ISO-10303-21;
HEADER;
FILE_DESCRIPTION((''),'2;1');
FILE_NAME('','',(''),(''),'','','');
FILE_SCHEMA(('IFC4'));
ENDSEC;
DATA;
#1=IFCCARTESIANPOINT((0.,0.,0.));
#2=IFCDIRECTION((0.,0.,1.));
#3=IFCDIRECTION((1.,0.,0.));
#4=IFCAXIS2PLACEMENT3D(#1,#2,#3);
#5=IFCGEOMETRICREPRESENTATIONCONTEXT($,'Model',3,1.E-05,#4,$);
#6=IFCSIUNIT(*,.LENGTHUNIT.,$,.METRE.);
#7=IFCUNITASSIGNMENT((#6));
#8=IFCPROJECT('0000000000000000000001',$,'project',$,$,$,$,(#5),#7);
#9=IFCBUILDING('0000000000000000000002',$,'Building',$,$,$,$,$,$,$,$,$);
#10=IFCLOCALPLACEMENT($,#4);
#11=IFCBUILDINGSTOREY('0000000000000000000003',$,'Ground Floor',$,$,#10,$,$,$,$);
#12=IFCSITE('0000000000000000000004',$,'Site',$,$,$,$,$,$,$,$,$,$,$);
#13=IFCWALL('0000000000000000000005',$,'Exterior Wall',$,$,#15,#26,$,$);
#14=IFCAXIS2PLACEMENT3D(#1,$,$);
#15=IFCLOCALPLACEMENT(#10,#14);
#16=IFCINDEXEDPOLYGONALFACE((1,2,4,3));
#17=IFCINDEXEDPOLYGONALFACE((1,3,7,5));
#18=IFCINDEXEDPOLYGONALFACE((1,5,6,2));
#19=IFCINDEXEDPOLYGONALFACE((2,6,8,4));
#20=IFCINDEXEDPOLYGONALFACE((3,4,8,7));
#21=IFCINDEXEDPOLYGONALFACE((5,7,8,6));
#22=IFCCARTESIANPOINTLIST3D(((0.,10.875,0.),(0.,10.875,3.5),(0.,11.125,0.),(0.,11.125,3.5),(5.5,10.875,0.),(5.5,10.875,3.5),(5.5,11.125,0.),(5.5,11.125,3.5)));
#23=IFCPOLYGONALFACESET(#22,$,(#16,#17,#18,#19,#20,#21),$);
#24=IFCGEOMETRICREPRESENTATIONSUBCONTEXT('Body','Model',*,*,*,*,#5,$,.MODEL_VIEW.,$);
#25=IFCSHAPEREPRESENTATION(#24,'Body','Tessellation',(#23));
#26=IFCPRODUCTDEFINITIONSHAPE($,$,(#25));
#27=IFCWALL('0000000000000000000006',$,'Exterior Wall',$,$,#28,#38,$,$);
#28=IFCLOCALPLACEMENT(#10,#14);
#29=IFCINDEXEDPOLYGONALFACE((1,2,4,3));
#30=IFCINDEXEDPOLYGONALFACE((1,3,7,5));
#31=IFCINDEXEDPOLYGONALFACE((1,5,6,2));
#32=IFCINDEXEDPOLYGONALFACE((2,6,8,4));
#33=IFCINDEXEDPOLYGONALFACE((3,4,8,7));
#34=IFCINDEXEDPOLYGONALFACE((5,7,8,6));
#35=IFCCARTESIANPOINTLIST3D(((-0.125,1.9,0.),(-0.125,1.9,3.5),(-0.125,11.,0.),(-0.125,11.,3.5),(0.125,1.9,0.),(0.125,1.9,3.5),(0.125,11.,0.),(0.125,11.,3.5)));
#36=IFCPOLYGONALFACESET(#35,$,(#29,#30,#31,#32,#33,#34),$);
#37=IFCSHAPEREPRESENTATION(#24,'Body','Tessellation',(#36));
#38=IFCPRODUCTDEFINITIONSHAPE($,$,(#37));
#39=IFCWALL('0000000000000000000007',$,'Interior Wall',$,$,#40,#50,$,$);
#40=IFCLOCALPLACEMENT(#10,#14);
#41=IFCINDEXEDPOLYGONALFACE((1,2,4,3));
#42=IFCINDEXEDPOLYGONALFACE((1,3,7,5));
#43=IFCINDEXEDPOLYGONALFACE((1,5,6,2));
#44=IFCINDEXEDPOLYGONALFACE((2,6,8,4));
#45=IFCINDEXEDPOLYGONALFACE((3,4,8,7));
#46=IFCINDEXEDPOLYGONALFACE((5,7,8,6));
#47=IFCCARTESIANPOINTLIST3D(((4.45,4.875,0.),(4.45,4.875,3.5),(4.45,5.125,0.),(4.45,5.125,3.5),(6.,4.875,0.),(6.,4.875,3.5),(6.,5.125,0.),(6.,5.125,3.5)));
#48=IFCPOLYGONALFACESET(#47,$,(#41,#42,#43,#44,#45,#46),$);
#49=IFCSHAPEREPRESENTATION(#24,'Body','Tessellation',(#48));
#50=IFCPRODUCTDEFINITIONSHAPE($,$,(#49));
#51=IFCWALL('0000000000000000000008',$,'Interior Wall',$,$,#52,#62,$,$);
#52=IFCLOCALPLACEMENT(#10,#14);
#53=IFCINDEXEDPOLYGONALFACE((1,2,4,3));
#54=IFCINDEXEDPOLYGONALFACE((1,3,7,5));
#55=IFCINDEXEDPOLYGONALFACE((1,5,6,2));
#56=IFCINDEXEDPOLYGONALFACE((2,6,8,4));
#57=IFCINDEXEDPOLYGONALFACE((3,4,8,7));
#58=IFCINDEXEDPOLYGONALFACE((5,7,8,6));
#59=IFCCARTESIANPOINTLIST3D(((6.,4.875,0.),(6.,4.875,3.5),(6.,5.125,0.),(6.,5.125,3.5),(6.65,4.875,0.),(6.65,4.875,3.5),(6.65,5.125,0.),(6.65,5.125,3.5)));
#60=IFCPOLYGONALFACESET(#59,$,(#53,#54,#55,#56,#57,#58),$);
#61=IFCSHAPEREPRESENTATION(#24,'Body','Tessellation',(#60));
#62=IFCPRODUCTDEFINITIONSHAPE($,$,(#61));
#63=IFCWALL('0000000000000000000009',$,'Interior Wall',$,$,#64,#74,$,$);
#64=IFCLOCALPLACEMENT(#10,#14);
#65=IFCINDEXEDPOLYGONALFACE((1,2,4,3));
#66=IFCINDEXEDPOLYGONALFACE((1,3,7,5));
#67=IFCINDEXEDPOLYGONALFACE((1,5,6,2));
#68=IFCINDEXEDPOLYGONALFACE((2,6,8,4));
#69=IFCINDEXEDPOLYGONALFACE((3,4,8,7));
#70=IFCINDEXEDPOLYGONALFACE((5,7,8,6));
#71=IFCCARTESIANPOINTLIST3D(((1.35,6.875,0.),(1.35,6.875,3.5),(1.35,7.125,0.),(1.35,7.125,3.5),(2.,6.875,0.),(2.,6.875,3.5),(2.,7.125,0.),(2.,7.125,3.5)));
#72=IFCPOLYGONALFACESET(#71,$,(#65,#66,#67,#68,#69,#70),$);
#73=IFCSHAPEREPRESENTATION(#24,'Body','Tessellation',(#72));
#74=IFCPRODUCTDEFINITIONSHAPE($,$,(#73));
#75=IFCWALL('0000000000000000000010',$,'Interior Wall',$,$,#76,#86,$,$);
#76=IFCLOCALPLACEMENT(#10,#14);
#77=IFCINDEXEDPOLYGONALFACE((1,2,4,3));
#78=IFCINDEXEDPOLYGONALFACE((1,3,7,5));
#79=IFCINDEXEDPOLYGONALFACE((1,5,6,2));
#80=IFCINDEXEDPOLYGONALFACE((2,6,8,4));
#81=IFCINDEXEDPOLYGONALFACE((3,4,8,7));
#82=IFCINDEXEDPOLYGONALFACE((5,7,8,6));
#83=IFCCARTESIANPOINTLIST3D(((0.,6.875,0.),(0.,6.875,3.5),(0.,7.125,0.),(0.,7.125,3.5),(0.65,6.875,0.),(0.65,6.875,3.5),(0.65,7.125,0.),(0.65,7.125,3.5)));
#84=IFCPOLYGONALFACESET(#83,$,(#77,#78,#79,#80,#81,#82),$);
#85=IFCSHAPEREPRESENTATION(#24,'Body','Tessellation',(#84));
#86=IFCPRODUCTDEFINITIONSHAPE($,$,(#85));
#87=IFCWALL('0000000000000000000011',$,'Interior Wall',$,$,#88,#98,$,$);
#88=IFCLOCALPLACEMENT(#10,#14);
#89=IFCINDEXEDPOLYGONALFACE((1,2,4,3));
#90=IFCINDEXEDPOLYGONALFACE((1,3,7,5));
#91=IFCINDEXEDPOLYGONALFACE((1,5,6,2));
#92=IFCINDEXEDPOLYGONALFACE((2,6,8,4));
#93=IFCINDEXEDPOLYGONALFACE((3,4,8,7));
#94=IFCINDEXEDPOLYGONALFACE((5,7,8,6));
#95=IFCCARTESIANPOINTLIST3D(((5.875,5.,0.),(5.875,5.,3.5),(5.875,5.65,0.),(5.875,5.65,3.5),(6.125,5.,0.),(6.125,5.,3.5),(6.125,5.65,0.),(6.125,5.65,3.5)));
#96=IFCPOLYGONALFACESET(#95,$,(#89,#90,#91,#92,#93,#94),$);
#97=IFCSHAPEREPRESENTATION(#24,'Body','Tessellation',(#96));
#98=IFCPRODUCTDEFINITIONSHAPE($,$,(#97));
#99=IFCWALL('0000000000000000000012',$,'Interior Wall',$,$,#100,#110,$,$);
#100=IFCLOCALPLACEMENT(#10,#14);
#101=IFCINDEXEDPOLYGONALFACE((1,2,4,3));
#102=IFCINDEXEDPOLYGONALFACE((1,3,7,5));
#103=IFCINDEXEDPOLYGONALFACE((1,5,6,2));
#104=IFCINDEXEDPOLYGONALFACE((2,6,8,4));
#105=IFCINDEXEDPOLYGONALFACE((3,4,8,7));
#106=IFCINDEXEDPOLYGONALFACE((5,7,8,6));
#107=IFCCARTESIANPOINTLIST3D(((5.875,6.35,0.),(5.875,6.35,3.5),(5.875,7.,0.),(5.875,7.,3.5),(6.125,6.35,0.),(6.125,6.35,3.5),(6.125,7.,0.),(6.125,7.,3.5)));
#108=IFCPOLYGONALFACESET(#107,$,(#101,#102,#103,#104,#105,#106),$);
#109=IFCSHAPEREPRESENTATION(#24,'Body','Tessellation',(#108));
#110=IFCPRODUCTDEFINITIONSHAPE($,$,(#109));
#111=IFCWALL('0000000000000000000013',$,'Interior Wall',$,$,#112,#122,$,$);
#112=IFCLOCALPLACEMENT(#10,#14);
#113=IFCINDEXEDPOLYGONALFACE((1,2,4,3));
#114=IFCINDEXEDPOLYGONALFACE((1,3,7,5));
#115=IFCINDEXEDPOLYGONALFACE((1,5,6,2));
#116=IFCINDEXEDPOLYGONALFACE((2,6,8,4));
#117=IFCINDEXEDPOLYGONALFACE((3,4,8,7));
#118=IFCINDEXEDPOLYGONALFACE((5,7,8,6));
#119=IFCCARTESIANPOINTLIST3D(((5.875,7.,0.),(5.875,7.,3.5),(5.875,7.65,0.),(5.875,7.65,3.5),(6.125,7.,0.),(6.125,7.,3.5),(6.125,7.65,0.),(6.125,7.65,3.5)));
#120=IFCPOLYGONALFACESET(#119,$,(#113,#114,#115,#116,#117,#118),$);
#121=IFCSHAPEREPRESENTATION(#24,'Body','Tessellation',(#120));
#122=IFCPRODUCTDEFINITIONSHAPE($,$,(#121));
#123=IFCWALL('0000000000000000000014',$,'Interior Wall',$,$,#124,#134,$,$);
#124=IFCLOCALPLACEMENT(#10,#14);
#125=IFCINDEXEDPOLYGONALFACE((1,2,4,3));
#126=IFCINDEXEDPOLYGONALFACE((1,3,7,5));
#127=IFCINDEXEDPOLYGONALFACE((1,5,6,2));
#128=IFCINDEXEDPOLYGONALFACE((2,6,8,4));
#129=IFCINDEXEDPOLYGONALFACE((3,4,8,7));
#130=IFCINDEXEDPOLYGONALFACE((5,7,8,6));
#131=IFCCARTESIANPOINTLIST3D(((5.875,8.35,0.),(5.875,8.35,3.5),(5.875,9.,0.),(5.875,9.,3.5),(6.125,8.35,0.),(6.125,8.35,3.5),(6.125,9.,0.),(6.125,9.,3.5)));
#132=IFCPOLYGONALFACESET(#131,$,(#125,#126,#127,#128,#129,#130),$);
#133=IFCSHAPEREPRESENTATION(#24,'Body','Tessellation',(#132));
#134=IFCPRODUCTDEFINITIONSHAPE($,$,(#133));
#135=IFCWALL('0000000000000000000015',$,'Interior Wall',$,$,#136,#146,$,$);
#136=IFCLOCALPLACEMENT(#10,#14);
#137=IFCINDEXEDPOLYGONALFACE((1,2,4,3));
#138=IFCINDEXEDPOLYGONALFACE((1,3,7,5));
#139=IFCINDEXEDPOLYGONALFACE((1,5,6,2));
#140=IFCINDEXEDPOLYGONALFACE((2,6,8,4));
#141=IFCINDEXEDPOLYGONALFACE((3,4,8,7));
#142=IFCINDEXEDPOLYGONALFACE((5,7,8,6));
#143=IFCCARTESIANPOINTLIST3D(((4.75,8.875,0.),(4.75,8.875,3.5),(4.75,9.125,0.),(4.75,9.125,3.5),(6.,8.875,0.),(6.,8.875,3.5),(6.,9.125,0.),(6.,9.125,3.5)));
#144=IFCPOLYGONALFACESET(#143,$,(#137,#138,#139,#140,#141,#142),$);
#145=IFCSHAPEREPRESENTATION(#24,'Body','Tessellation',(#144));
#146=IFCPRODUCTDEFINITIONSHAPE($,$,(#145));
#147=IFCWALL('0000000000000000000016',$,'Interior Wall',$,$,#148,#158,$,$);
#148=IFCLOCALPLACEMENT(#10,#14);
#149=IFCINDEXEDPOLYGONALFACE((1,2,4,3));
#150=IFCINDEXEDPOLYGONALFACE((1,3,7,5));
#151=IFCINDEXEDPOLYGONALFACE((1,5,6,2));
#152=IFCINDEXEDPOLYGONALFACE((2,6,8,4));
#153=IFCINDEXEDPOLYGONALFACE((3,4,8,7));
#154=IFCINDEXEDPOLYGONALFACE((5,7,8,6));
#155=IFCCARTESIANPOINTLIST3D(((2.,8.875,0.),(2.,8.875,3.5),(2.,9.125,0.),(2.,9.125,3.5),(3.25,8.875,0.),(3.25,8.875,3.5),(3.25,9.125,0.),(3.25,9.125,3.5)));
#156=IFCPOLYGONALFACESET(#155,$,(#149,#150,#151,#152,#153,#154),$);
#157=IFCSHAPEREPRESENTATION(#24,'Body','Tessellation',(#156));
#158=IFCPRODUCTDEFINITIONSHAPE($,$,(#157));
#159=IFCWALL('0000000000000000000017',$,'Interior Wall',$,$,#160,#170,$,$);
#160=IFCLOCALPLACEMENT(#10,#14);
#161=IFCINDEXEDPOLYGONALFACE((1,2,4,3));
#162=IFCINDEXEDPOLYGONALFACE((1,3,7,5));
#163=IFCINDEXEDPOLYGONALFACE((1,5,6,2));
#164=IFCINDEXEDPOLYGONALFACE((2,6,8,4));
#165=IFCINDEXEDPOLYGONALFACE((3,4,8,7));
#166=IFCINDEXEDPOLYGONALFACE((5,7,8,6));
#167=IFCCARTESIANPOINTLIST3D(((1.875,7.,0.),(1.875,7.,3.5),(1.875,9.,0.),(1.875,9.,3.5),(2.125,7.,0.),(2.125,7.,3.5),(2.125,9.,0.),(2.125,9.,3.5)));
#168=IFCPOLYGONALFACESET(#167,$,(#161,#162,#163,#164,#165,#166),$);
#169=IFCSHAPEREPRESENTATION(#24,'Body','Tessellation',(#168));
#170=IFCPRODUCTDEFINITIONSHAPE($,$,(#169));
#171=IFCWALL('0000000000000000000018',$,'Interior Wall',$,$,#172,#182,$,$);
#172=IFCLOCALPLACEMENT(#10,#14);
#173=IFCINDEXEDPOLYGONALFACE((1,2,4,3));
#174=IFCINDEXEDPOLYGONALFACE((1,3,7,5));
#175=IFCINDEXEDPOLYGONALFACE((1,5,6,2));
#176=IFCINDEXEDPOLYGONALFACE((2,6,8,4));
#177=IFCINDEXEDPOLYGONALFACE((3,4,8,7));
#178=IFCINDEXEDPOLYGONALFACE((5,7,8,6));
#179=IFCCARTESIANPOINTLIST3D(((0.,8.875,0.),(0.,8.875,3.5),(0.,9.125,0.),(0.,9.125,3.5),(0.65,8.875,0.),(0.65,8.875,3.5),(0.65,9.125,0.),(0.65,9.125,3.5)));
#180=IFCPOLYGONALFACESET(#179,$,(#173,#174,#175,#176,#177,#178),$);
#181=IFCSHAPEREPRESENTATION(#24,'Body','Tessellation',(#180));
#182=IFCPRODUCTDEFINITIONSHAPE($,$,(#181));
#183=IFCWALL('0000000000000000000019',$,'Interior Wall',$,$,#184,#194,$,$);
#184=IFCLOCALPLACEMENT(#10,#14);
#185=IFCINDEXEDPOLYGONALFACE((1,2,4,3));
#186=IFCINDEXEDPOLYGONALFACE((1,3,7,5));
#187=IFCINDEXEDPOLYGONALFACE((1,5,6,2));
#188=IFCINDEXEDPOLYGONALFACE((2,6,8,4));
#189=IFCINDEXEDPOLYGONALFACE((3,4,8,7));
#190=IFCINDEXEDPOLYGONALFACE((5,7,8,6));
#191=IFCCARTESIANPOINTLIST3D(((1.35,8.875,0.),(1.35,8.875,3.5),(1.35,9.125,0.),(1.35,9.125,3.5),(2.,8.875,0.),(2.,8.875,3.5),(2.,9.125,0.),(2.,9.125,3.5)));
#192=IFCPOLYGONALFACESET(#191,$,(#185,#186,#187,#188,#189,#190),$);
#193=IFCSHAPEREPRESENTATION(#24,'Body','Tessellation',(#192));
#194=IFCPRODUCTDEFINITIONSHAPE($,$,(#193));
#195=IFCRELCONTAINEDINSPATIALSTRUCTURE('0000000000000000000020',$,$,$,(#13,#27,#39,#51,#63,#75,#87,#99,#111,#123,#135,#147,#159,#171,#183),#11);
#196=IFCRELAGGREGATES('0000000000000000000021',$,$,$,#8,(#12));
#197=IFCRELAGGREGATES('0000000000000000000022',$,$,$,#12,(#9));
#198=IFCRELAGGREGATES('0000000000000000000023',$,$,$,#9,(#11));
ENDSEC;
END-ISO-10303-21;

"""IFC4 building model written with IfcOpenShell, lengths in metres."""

from ifc_helpers import new_model, si_unit, frame, origin_with_axes, place, context, subcontext, project, spatial, indexed_curve, outline, extrude, element, save


model = new_model("IFC4")

# Units and contexts
model_context = context("Model", 3, precision=1e-05, world=origin_with_axes())
body_context = subcontext(model_context, "Body", "Model", "MODEL_VIEW")
ifc_project = project(units=[si_unit("LENGTHUNIT", "METRE")], contexts=[model_context])

# Site, building, storey
site = spatial("IfcSite", under=ifc_project, Name="Site")
building = spatial("IfcBuilding", under=site, Name="Building")
storey_placement = place(None, origin_with_axes())
storey = spatial("IfcBuildingStorey", under=building, at=storey_placement, Name="Ground Floor")

# Walls
wall_1_placement = place(storey_placement, frame((5.5, 11.0, 0.0), z_axis=(0.0, 0.0, 1.0), x_axis=(-1.0, 0.0, 0.0)))
element("IfcWall", 1, at=wall_1_placement, inside=storey, Name="Exterior Wall", context=body_context, shape_type="SweptSolid", body=[
    extrude(outline(indexed_curve([(0.0, 0.0), (0.0, 0.25), (5.5, 0.25), (5.5, 0.0), (0.0, 0.0)], self_intersect=False)), frame((0.0, -0.125, 0.0), z_axis=(0.0, 0.0, 1.0), x_axis=(1.0, 0.0, 0.0)), (0.0, 0.0, 1.0), 3.5),
])
wall_2_placement = place(storey_placement, frame((0.0, 11.0, 0.0), z_axis=(0.0, 0.0, 1.0), x_axis=(0.0, -1.0, 0.0)))
element("IfcWall", 2, at=wall_2_placement, inside=storey, Name="Exterior Wall", context=body_context, shape_type="SweptSolid", body=[
    extrude(outline(indexed_curve([(0.0, 0.0), (0.0, 0.25), (9.1, 0.25), (9.1, 0.0), (0.0, 0.0)], self_intersect=False)), frame((0.0, -0.125, 0.0), z_axis=(0.0, 0.0, 1.0), x_axis=(1.0, 0.0, 0.0)), (0.0, 0.0, 1.0), 3.5),
])
wall_3_placement = place(storey_placement, frame((6.0, 5.0, 0.0), z_axis=(0.0, 0.0, 1.0), x_axis=(-1.0, 0.0, 0.0)))
element("IfcWall", 3, at=wall_3_placement, inside=storey, Name="Interior Wall", context=body_context, shape_type="SweptSolid", body=[
    extrude(outline(indexed_curve([(0.0, 0.0), (0.0, 0.25), (1.55, 0.25), (1.55, 0.0), (0.0, 0.0)], self_intersect=False)), frame((0.0, -0.125, 0.0), z_axis=(0.0, 0.0, 1.0), x_axis=(1.0, 0.0, 0.0)), (0.0, 0.0, 1.0), 3.5),
])
wall_4_placement = place(storey_placement, frame((6.65, 5.0, 0.0), z_axis=(0.0, 0.0, 1.0), x_axis=(-1.0, 0.0, 0.0)))
element("IfcWall", 4, at=wall_4_placement, inside=storey, Name="Interior Wall", context=body_context, shape_type="SweptSolid", body=[
    extrude(outline(indexed_curve([(0.0, 0.0), (0.0, 0.25), (0.65, 0.25), (0.65, 0.0), (0.0, 0.0)], self_intersect=False)), frame((0.0, -0.125, 0.0), z_axis=(0.0, 0.0, 1.0), x_axis=(1.0, 0.0, 0.0)), (0.0, 0.0, 1.0), 3.5),
])
for number, where, z_axis, x_axis, name in (
    (5, (2.0, 7.0, 0.0), (0.0, 0.0, 1.0), (-1.0, 0.0, 0.0), "Interior Wall"),
    (6, (0.65, 7.0, 0.0), (0.0, 0.0, 1.0), (-1.0, 0.0, 0.0), "Interior Wall"),
):
    element("IfcWall", number, at=place(storey_placement, frame(where, z_axis=z_axis, x_axis=x_axis)), inside=storey, Name=name, context=body_context, shape_type="SweptSolid", body=[
        extrude(outline(indexed_curve([(0.0, 0.0), (0.0, 0.25), (0.65, 0.25), (0.65, 0.0), (0.0, 0.0)], self_intersect=False)), frame((0.0, -0.125, 0.0), z_axis=(0.0, 0.0, 1.0), x_axis=(1.0, 0.0, 0.0)), (0.0, 0.0, 1.0), 3.5),
    ])
for number, where, z_axis, x_axis, name in (
    (7, (6.0, 5.0, 0.0), (0.0, 0.0, 1.0), (0.0, 1.0, 0.0), "Interior Wall"),
    (8, (6.0, 6.35, 0.0), (0.0, 0.0, 1.0), (0.0, 1.0, 0.0), "Interior Wall"),
    (9, (6.0, 7.0, 0.0), (0.0, 0.0, 1.0), (0.0, 1.0, 0.0), "Interior Wall"),
    (10, (6.0, 8.35, 0.0), (0.0, 0.0, 1.0), (0.0, 1.0, 0.0), "Interior Wall"),
):
    element("IfcWall", number, at=place(storey_placement, frame(where, z_axis=z_axis, x_axis=x_axis)), inside=storey, Name=name, context=body_context, shape_type="SweptSolid", body=[
        extrude(outline(indexed_curve([(0.0, 0.0), (0.0, 0.25), (0.65, 0.25), (0.65, 0.0), (0.0, 0.0)], self_intersect=False)), frame((0.0, -0.125, 0.0), z_axis=(0.0, 0.0, 1.0), x_axis=(1.0, 0.0, 0.0)), (0.0, 0.0, 1.0), 3.5),
    ])
for number, where, z_axis, x_axis, name in (
    (11, (6.0, 9.0, 0.0), (0.0, 0.0, 1.0), (-1.0, 0.0, 0.0), "Interior Wall"),
    (12, (3.25, 9.0, 0.0), (0.0, 0.0, 1.0), (-1.0, 0.0, 0.0), "Interior Wall"),
):
    element("IfcWall", number, at=place(storey_placement, frame(where, z_axis=z_axis, x_axis=x_axis)), inside=storey, Name=name, context=body_context, shape_type="SweptSolid", body=[
        extrude(outline(indexed_curve([(0.0, 0.0), (0.0, 0.25), (1.25, 0.25), (1.25, 0.0), (0.0, 0.0)], self_intersect=False)), frame((0.0, -0.125, 0.0), z_axis=(0.0, 0.0, 1.0), x_axis=(1.0, 0.0, 0.0)), (0.0, 0.0, 1.0), 3.5),
    ])
wall_5_placement = place(storey_placement, frame((2.0, 9.0, 0.0), z_axis=(0.0, 0.0, 1.0), x_axis=(0.0, -1.0, 0.0)))
element("IfcWall", 13, at=wall_5_placement, inside=storey, Name="Interior Wall", context=body_context, shape_type="SweptSolid", body=[
    extrude(outline(indexed_curve([(0.0, 0.0), (0.0, 0.25), (2.0, 0.25), (2.0, 0.0), (0.0, 0.0)], self_intersect=False)), frame((0.0, -0.125, 0.0), z_axis=(0.0, 0.0, 1.0), x_axis=(1.0, 0.0, 0.0)), (0.0, 0.0, 1.0), 3.5),
])
wall_6_placement = place(storey_placement, frame((0.0, 9.0, 0.0), z_axis=(0.0, 0.0, 1.0), x_axis=(1.0, 0.0, 0.0)))
element("IfcWall", 14, at=wall_6_placement, inside=storey, Name="Interior Wall", context=body_context, shape_type="SweptSolid", body=[
    extrude(outline(indexed_curve([(0.0, 0.0), (0.0, 0.25), (0.65, 0.25), (0.65, 0.0), (0.0, 0.0)], self_intersect=False)), frame((0.0, -0.125, 0.0), z_axis=(0.0, 0.0, 1.0), x_axis=(1.0, 0.0, 0.0)), (0.0, 0.0, 1.0), 3.5),
])
wall_7_placement = place(storey_placement, frame((1.35, 9.0, 0.0), z_axis=(0.0, 0.0, 1.0), x_axis=(1.0, 0.0, 0.0)))
element("IfcWall", 15, at=wall_7_placement, inside=storey, Name="Interior Wall", context=body_context, shape_type="SweptSolid", body=[
    extrude(outline(indexed_curve([(0.0, 0.0), (0.0, 0.25), (0.65, 0.25), (0.65, 0.0), (0.0, 0.0)], self_intersect=False)), frame((0.0, -0.125, 0.0), z_axis=(0.0, 0.0, 1.0), x_axis=(1.0, 0.0, 0.0)), (0.0, 0.0, 1.0), 3.5),
])

save(model, "model.ifc")
